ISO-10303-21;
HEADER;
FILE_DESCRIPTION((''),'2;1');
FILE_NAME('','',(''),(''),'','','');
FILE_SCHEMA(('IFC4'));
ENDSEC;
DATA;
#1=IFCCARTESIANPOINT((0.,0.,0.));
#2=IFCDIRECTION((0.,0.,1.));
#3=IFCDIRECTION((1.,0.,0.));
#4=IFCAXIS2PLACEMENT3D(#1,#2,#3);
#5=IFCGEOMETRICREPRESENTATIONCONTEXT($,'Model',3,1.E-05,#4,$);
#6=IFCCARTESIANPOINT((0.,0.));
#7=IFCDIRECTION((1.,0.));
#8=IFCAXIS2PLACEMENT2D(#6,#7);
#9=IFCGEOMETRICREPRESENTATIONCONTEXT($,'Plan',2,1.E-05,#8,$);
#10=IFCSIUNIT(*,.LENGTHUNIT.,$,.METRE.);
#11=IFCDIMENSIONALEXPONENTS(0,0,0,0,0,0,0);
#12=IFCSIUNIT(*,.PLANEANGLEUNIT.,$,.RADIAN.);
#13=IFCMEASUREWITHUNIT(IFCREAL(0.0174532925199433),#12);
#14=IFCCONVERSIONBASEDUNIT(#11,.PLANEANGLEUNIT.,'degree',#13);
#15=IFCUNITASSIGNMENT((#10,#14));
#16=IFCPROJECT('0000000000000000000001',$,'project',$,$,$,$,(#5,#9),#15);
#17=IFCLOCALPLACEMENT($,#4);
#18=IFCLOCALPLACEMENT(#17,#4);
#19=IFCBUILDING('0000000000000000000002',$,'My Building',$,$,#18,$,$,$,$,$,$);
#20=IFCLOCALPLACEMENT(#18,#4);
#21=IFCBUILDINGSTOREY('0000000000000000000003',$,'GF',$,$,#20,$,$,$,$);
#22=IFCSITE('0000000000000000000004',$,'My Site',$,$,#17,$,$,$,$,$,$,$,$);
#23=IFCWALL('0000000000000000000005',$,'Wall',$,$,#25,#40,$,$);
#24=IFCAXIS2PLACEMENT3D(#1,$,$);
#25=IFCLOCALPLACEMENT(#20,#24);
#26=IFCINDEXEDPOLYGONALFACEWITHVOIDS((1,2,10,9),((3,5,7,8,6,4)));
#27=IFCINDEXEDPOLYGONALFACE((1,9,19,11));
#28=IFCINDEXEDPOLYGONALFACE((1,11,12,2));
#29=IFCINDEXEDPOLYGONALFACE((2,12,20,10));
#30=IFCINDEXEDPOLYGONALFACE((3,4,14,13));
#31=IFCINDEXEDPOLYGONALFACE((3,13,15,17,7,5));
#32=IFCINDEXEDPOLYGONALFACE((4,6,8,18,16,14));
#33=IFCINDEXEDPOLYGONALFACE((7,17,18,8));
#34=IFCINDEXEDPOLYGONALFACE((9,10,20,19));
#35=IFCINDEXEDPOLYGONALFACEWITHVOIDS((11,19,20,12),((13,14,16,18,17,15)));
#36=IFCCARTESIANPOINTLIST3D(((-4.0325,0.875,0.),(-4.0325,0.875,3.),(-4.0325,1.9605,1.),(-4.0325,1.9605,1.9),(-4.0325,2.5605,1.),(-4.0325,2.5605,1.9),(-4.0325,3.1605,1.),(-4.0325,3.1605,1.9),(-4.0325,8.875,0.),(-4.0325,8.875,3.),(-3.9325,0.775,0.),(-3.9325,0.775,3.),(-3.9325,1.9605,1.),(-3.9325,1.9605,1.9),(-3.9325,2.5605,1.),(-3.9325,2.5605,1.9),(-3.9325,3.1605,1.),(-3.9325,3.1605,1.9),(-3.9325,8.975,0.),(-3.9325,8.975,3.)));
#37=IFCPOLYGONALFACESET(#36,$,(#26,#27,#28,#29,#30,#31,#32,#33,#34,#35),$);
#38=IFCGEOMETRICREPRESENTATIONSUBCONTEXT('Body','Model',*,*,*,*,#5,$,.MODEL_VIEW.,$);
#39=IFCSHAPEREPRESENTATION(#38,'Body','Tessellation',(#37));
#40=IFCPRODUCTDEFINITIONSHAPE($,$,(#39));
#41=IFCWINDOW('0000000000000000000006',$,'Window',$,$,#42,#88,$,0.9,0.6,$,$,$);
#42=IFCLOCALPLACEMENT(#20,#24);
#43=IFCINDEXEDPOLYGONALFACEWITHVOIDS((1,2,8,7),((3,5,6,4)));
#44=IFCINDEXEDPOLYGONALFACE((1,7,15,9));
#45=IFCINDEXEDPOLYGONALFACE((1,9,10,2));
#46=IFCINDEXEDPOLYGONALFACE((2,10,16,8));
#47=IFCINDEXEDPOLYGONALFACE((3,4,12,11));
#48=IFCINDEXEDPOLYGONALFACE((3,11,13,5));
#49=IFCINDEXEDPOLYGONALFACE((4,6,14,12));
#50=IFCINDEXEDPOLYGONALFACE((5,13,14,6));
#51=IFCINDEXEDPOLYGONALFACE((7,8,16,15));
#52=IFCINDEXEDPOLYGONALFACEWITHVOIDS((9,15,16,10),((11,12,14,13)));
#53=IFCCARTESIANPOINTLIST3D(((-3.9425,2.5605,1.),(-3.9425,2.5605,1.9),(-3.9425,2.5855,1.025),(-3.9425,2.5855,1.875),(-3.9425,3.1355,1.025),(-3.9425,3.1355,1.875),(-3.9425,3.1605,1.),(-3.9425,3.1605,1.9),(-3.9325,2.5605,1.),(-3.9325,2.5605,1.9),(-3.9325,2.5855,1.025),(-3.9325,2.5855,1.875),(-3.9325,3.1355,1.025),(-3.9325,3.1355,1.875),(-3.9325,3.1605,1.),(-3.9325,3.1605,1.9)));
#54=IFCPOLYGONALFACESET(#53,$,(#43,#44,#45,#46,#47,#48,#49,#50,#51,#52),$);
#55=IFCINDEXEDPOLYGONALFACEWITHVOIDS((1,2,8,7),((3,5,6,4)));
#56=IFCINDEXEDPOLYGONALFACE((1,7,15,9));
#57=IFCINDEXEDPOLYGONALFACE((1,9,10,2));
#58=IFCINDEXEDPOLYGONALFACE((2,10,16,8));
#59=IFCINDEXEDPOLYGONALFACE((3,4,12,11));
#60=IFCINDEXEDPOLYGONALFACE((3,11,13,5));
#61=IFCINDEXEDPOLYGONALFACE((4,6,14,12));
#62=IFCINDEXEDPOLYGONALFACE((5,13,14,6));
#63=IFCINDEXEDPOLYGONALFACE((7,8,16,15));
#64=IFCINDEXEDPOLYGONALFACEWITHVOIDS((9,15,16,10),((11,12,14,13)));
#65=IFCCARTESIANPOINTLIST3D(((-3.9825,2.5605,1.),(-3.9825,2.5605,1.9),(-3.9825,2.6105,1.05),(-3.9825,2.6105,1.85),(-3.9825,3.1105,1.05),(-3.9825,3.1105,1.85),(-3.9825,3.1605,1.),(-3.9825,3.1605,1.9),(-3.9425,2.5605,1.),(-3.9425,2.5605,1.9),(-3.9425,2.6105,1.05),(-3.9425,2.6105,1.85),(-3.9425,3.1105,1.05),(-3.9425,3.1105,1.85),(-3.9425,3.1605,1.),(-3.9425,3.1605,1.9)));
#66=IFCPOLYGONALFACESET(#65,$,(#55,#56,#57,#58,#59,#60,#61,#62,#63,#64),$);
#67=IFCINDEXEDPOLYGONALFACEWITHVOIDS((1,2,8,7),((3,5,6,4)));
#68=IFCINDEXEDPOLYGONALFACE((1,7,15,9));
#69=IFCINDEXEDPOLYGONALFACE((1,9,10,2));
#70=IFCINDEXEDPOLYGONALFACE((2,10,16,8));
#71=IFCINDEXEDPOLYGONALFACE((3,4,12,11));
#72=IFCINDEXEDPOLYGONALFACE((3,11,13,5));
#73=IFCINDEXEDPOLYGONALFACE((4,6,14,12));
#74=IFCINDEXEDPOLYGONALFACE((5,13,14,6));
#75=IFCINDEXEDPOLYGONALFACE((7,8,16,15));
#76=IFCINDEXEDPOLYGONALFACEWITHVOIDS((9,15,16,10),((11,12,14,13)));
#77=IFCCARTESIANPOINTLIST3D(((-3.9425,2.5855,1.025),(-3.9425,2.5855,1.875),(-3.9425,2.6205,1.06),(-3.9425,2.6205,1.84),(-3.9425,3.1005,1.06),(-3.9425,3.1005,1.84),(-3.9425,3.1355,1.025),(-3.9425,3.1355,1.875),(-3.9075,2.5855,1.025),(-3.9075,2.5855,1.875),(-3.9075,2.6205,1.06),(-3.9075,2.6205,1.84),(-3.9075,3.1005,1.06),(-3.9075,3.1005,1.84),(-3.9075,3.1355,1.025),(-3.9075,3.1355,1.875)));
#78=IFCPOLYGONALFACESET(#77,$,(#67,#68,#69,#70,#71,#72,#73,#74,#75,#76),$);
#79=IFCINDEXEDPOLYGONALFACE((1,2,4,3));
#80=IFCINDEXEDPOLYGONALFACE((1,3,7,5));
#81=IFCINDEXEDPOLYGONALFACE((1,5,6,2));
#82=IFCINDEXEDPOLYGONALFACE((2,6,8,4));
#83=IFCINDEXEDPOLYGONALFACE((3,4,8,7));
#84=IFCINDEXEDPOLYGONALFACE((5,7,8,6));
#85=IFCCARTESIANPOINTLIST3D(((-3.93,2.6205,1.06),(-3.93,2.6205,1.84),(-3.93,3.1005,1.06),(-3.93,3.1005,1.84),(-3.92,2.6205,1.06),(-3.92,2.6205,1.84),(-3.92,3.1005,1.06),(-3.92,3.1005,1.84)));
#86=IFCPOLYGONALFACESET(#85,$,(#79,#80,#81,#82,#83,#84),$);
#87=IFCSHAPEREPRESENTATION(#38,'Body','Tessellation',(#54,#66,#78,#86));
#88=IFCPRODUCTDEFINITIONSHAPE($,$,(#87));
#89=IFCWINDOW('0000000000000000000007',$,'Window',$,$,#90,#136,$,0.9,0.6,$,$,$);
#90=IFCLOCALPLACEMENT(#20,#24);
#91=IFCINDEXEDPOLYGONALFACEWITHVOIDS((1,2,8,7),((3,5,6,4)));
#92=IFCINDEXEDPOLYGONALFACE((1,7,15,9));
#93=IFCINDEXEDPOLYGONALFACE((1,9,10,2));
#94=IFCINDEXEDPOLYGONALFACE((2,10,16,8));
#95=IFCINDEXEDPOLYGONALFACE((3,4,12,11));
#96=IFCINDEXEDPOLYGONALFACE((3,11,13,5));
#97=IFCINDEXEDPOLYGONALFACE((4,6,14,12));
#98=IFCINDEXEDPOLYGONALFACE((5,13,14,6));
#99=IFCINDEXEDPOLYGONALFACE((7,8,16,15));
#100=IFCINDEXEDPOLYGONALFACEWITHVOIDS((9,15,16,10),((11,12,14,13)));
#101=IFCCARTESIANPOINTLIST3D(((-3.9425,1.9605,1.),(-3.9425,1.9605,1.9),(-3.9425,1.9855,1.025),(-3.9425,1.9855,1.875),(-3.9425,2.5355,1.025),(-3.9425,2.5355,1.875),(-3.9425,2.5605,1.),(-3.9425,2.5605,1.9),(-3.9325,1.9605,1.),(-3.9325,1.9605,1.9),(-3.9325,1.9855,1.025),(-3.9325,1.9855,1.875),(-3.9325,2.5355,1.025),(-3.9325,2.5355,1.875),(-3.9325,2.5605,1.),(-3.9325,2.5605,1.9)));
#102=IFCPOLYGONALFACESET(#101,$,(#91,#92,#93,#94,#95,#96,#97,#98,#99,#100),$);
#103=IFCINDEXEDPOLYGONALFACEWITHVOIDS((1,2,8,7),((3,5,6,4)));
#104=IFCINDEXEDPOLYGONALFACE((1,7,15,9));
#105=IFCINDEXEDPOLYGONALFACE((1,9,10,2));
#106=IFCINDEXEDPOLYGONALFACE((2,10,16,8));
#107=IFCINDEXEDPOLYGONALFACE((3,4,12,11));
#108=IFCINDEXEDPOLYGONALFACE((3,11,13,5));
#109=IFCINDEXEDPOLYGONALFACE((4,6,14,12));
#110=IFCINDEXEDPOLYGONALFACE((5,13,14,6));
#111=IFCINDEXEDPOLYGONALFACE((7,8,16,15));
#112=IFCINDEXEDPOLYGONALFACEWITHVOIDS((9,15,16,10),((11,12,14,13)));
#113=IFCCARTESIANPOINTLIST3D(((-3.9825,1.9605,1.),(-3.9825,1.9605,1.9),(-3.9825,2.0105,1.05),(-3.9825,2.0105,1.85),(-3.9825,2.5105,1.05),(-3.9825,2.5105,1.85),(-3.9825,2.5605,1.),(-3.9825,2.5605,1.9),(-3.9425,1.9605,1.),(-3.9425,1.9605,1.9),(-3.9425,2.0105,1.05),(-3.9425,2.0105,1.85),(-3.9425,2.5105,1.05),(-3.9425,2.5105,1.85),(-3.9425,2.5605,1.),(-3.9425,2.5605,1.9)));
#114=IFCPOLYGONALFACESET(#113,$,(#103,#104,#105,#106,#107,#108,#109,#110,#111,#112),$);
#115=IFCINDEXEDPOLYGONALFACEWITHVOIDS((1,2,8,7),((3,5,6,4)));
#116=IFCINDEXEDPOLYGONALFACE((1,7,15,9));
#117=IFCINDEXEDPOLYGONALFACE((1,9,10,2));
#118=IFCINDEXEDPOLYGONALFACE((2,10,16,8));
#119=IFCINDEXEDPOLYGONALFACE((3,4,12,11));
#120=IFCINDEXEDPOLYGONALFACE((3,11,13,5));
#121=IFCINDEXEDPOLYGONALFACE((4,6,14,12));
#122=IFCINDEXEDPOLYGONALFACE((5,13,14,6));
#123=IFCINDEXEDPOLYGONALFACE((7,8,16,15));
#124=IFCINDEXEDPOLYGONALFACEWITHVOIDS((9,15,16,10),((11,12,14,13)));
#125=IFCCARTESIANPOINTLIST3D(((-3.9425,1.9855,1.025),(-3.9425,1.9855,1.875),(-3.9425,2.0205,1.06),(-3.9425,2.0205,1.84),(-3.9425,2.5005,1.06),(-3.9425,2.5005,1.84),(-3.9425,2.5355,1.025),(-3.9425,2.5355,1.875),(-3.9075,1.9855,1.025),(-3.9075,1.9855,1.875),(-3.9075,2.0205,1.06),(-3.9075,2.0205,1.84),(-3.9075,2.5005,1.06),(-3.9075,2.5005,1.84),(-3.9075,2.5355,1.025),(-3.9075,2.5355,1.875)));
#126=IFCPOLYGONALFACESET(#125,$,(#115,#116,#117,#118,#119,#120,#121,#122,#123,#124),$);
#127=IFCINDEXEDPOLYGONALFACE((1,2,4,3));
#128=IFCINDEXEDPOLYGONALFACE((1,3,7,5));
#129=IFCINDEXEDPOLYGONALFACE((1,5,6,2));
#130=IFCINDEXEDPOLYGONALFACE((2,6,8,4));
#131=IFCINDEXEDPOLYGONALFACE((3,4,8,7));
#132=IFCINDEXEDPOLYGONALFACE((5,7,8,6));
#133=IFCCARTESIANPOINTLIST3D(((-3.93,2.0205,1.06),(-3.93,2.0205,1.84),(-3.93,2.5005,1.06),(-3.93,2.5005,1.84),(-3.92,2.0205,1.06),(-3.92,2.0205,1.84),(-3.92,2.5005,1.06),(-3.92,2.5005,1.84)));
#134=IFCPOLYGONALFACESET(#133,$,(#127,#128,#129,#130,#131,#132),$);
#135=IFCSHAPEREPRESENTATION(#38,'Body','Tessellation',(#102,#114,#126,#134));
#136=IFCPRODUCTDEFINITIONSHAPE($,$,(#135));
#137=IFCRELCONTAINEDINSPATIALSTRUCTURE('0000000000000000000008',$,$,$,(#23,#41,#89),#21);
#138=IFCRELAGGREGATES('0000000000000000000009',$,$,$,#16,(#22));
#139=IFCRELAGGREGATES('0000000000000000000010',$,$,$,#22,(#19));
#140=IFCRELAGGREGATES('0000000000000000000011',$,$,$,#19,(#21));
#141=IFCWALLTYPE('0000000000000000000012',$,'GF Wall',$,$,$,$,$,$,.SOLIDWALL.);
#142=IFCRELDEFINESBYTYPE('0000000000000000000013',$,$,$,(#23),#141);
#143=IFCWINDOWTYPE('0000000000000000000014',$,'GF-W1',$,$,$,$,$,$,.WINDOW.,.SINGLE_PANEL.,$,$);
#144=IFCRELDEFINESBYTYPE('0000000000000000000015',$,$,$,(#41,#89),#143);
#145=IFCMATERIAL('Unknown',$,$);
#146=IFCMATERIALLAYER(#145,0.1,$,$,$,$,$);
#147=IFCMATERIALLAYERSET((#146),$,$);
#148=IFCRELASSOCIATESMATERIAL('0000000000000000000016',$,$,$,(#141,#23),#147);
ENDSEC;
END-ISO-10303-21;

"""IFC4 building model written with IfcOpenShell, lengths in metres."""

from ifc_helpers import new_model, entity, si_unit, converted_unit, frame, origin_with_axes, origin_2d_with_axis, place, context, subcontext, project, spatial, line, indexed_curve, outline, extrude, shape, source, transform, mapped, material, layer, layer_set, layer_usage, type_object, type_shapes, element, fill, save


model = new_model("IFC4")

# Units and contexts
model_context = context("Model", 3, precision=1e-05, world=origin_with_axes())
plan_context = context("Plan", 2, precision=1e-05, world=origin_2d_with_axis())
body_context_1 = subcontext(model_context, "Body", "Model", "MODEL_VIEW")
body_context_2 = subcontext(plan_context, "Body", "Plan", "PLAN_VIEW")
ifc_project = project(units=[si_unit("LENGTHUNIT", "METRE"), converted_unit("PLANEANGLEUNIT", "degree", entity("IfcReal", 0.0174532925199433), si_unit("PLANEANGLEUNIT", "RADIAN"), dimensions=[0, 0, 0, 0, 0, 0, 0])], contexts=[model_context, plan_context])

# Site, building, storey
site_placement = place(None, origin_with_axes())
site = spatial("IfcSite", under=ifc_project, at=site_placement, Name="My Site")
building_placement = place(site_placement, origin_with_axes())
building = spatial("IfcBuilding", under=site, at=building_placement, Name="My Building")
storey_placement = place(building_placement, origin_with_axes())
storey = spatial("IfcBuildingStorey", under=building, at=storey_placement, Name="GF")

# Shared definitions
ifc_material = material(Name="Unknown")

# Wall, openings, windows
ifc_layer = layer(ifc_material, 0.1)
ifc_layer_set = layer_set([ifc_layer])
ifc_layer_usage_1 = layer_usage(ifc_layer_set, "AXIS2", "POSITIVE", 0.0)
wall_type = type_object("IfcWallType", Name="GF Wall", PredefinedType="SOLIDWALL", material=ifc_layer_set)
wall_1_placement = place(storey_placement, frame((-4.0325, 8.875, 0.0), z_axis=(0.0, 0.0, 1.0), x_axis=(0.0, -1.0, 0.0)))
wall_1 = element("IfcWall", 1, at=wall_1_placement, inside=storey, type_object=wall_type, material=ifc_layer_usage_1, Name="Wall", context=body_context_1, shape_type="SweptSolid", body=[
    extrude(outline(indexed_curve([(0.0, 0.0), (-0.1, 0.1), (8.1, 0.1), (8.0, 0.0)], segments=[line(1, 2, 3, 4, 1)])), origin_with_axes(), (0.0, 0.0, 1.0), 3.0),
])
shared_shape_1 = source(origin_with_axes(), body_context_1, "Body", "SweptSolid", [
    extrude(outline(indexed_curve([(0.0, 0.0), (0.6, 0.0), (0.6, 0.9), (0.0, 0.9)], segments=[line(1, 2, 3, 4, 1)])), frame((0.0, -0.6, 0.0), z_axis=(0.0, -1.0, 0.0), x_axis=(1.0, 0.0, 0.0)), (0.0, 0.0, -1.0), 1.2),
])
opening_1_placement = place(wall_1_placement, frame((5.7145, 0.0, 1.0), z_axis=(0.0, 0.0, 1.0), x_axis=(1.0, 0.0, 0.0)))
opening_1 = element("IfcOpeningElement", 2, at=opening_1_placement, cuts=wall_1, PredefinedType="OPENING", context=body_context_1, shape_type="MappedRepresentation", body=[
    mapped(shared_shape_1, transform((0.0, 0.0, 0.0), x_axis=(1.0, 0.0, 0.0), y_axis=(0.0, 1.0, 0.0), z_axis=(0.0, 0.0, 1.0), scale=1.0)),
])
opening_2_placement = place(wall_1_placement, frame((6.3145, 0.0, 1.0), z_axis=(0.0, 0.0, 1.0), x_axis=(1.0, 0.0, 0.0)))
opening_2 = element("IfcOpeningElement", 3, at=opening_2_placement, cuts=wall_1, PredefinedType="OPENING", context=body_context_1, shape_type="MappedRepresentation", body=[
    mapped(shared_shape_1, transform((0.0, 0.0, 0.0), x_axis=(1.0, 0.0, 0.0), y_axis=(0.0, 1.0, 0.0), z_axis=(0.0, 0.0, 1.0), scale=1.0)),
])
window_type = type_object("IfcWindowType", Name="GF-W1", PartitioningType="SINGLE_PANEL", PredefinedType="WINDOW")
shared_shape_2 = source(origin_with_axes(), body_context_1, "Body", "SweptSolid", [
    extrude(outline(indexed_curve([(0.0, 0.0), (0.6, 0.0), (0.6, 0.9), (0.0, 0.9)], segments=[line(1, 2, 3, 4, 1)]), holes=[indexed_curve([(0.025, 0.025), (0.575, 0.025), (0.575, 0.875), (0.025, 0.875)], segments=[line(1, 2, 3, 4, 1)])]), frame((0.0, 0.09, 0.0), z_axis=(0.0, -1.0, 0.0), x_axis=(1.0, 0.0, 0.0)), (0.0, 0.0, -1.0), 0.01),
    extrude(outline(indexed_curve([(0.0, 0.0), (0.6, 0.0), (0.6, 0.9), (0.0, 0.9)], segments=[line(1, 2, 3, 4, 1)]), holes=[indexed_curve([(0.05, 0.05), (0.55, 0.05), (0.55, 0.85), (0.05, 0.85)], segments=[line(1, 2, 3, 4, 1)])]), frame((0.0, 0.05, 0.0), z_axis=(0.0, -1.0, 0.0), x_axis=(1.0, 0.0, 0.0)), (0.0, 0.0, -1.0), 0.04),
    extrude(outline(indexed_curve([(0.0, 0.0), (0.55, 0.0), (0.55, 0.85), (0.0, 0.85)], segments=[line(1, 2, 3, 4, 1)]), holes=[indexed_curve([(0.035, 0.035), (0.515, 0.035), (0.515, 0.815), (0.035, 0.815)], segments=[line(1, 2, 3, 4, 1)])]), frame((0.025, 0.09, 0.025), z_axis=(0.0, -1.0, 0.0), x_axis=(1.0, 0.0, 0.0)), (0.0, 0.0, -1.0), 0.035),
    extrude(outline(indexed_curve([(0.035, 0.035), (0.515, 0.035), (0.515, 0.815), (0.035, 0.815)], segments=[line(1, 2, 3, 4, 1)])), frame((0.025, 0.1025, 0.025), z_axis=(0.0, -1.0, 0.0), x_axis=(1.0, 0.0, 0.0)), (0.0, 0.0, -1.0), 0.01),
])
shared_shape_3 = source(origin_with_axes(), body_context_2, "Body", "Curve2D", [
    entity("IfcIndexedPolyCurve", entity("IfcCartesianPointList2D", [[0.05, 0.05], [0.55, 0.05]])),
    entity("IfcIndexedPolyCurve", entity("IfcCartesianPointList2D", [[0.0, 0.1], [0.025, 0.1], [0.025, 0.09], [0.05, 0.09], [0.05, 0.05], [0.0, 0.05]]), [entity("IfcLineIndex", [1, 2, 3, 4, 5, 6, 1])]),
    entity("IfcIndexedPolyCurve", entity("IfcCartesianPointList2D", [[0.6, 0.1], [0.575, 0.1], [0.575, 0.09], [0.55, 0.09], [0.55, 0.05], [0.6, 0.05]]), [entity("IfcLineIndex", [1, 2, 3, 4, 5, 6, 1])]),
    entity("IfcIndexedPolyCurve", entity("IfcCartesianPointList2D", [[0.025, 0.09], [0.06, 0.09], [0.06, 0.125], [0.025, 0.125]]), [entity("IfcLineIndex", [1, 2, 3, 4, 1])]),
    entity("IfcIndexedPolyCurve", entity("IfcCartesianPointList2D", [[0.575, 0.09], [0.54, 0.09], [0.54, 0.125], [0.575, 0.125]]), [entity("IfcLineIndex", [1, 2, 3, 4, 1])]),
    entity("IfcIndexedPolyCurve", entity("IfcCartesianPointList2D", [[0.06, 0.09], [0.54, 0.09]])),
    entity("IfcIndexedPolyCurve", entity("IfcCartesianPointList2D", [[0.06, 0.125], [0.54, 0.125]])),
    entity("IfcIndexedPolyCurve", entity("IfcCartesianPointList2D", [[0.06, 0.1075], [0.54, 0.1075]])),
])
type_shapes(window_type, [shared_shape_2, shared_shape_3])
window_1_placement = place(opening_1_placement, frame((0.0, 0.0, 0.0), z_axis=(0.0, 0.0, 1.0), x_axis=(1.0, 0.0, 0.0)))
window_1 = element("IfcWindow", 4, at=window_1_placement, inside=storey, type_object=window_type, Name="Window", OverallHeight=0.9, OverallWidth=0.6, shapes=[
    shape(body_context_1, "Body", "MappedRepresentation", [mapped(shared_shape_2, transform((0.0, 0.0, 0.0), x_axis=(1.0, 0.0, 0.0), y_axis=(0.0, 1.0, 0.0), z_axis=(0.0, 0.0, 1.0), scale=1.0))]),
    shape(body_context_2, "Body", "MappedRepresentation", [mapped(shared_shape_3, transform((0.0, 0.0, 0.0), x_axis=(1.0, 0.0, 0.0), y_axis=(0.0, 1.0, 0.0), z_axis=(0.0, 0.0, 1.0), scale=1.0))]),
])
fill(opening_1, window_1)
window_2_placement = place(opening_2_placement, frame((0.0, 0.0, 0.0), z_axis=(0.0, 0.0, 1.0), x_axis=(1.0, 0.0, 0.0)))
window_2 = element("IfcWindow", 5, at=window_2_placement, inside=storey, type_object=window_type, Name="Window", OverallHeight=0.9, OverallWidth=0.6, shapes=[
    shape(body_context_1, "Body", "MappedRepresentation", [mapped(shared_shape_2, transform((0.0, 0.0, 0.0), x_axis=(1.0, 0.0, 0.0), y_axis=(0.0, 1.0, 0.0), z_axis=(0.0, 0.0, 1.0), scale=1.0))]),
    shape(body_context_2, "Body", "MappedRepresentation", [mapped(shared_shape_3, transform((0.0, 0.0, 0.0), x_axis=(1.0, 0.0, 0.0), y_axis=(0.0, 1.0, 0.0), z_axis=(0.0, 0.0, 1.0), scale=1.0))]),
])
fill(opening_2, window_2)

save(model, "model.ifc")
